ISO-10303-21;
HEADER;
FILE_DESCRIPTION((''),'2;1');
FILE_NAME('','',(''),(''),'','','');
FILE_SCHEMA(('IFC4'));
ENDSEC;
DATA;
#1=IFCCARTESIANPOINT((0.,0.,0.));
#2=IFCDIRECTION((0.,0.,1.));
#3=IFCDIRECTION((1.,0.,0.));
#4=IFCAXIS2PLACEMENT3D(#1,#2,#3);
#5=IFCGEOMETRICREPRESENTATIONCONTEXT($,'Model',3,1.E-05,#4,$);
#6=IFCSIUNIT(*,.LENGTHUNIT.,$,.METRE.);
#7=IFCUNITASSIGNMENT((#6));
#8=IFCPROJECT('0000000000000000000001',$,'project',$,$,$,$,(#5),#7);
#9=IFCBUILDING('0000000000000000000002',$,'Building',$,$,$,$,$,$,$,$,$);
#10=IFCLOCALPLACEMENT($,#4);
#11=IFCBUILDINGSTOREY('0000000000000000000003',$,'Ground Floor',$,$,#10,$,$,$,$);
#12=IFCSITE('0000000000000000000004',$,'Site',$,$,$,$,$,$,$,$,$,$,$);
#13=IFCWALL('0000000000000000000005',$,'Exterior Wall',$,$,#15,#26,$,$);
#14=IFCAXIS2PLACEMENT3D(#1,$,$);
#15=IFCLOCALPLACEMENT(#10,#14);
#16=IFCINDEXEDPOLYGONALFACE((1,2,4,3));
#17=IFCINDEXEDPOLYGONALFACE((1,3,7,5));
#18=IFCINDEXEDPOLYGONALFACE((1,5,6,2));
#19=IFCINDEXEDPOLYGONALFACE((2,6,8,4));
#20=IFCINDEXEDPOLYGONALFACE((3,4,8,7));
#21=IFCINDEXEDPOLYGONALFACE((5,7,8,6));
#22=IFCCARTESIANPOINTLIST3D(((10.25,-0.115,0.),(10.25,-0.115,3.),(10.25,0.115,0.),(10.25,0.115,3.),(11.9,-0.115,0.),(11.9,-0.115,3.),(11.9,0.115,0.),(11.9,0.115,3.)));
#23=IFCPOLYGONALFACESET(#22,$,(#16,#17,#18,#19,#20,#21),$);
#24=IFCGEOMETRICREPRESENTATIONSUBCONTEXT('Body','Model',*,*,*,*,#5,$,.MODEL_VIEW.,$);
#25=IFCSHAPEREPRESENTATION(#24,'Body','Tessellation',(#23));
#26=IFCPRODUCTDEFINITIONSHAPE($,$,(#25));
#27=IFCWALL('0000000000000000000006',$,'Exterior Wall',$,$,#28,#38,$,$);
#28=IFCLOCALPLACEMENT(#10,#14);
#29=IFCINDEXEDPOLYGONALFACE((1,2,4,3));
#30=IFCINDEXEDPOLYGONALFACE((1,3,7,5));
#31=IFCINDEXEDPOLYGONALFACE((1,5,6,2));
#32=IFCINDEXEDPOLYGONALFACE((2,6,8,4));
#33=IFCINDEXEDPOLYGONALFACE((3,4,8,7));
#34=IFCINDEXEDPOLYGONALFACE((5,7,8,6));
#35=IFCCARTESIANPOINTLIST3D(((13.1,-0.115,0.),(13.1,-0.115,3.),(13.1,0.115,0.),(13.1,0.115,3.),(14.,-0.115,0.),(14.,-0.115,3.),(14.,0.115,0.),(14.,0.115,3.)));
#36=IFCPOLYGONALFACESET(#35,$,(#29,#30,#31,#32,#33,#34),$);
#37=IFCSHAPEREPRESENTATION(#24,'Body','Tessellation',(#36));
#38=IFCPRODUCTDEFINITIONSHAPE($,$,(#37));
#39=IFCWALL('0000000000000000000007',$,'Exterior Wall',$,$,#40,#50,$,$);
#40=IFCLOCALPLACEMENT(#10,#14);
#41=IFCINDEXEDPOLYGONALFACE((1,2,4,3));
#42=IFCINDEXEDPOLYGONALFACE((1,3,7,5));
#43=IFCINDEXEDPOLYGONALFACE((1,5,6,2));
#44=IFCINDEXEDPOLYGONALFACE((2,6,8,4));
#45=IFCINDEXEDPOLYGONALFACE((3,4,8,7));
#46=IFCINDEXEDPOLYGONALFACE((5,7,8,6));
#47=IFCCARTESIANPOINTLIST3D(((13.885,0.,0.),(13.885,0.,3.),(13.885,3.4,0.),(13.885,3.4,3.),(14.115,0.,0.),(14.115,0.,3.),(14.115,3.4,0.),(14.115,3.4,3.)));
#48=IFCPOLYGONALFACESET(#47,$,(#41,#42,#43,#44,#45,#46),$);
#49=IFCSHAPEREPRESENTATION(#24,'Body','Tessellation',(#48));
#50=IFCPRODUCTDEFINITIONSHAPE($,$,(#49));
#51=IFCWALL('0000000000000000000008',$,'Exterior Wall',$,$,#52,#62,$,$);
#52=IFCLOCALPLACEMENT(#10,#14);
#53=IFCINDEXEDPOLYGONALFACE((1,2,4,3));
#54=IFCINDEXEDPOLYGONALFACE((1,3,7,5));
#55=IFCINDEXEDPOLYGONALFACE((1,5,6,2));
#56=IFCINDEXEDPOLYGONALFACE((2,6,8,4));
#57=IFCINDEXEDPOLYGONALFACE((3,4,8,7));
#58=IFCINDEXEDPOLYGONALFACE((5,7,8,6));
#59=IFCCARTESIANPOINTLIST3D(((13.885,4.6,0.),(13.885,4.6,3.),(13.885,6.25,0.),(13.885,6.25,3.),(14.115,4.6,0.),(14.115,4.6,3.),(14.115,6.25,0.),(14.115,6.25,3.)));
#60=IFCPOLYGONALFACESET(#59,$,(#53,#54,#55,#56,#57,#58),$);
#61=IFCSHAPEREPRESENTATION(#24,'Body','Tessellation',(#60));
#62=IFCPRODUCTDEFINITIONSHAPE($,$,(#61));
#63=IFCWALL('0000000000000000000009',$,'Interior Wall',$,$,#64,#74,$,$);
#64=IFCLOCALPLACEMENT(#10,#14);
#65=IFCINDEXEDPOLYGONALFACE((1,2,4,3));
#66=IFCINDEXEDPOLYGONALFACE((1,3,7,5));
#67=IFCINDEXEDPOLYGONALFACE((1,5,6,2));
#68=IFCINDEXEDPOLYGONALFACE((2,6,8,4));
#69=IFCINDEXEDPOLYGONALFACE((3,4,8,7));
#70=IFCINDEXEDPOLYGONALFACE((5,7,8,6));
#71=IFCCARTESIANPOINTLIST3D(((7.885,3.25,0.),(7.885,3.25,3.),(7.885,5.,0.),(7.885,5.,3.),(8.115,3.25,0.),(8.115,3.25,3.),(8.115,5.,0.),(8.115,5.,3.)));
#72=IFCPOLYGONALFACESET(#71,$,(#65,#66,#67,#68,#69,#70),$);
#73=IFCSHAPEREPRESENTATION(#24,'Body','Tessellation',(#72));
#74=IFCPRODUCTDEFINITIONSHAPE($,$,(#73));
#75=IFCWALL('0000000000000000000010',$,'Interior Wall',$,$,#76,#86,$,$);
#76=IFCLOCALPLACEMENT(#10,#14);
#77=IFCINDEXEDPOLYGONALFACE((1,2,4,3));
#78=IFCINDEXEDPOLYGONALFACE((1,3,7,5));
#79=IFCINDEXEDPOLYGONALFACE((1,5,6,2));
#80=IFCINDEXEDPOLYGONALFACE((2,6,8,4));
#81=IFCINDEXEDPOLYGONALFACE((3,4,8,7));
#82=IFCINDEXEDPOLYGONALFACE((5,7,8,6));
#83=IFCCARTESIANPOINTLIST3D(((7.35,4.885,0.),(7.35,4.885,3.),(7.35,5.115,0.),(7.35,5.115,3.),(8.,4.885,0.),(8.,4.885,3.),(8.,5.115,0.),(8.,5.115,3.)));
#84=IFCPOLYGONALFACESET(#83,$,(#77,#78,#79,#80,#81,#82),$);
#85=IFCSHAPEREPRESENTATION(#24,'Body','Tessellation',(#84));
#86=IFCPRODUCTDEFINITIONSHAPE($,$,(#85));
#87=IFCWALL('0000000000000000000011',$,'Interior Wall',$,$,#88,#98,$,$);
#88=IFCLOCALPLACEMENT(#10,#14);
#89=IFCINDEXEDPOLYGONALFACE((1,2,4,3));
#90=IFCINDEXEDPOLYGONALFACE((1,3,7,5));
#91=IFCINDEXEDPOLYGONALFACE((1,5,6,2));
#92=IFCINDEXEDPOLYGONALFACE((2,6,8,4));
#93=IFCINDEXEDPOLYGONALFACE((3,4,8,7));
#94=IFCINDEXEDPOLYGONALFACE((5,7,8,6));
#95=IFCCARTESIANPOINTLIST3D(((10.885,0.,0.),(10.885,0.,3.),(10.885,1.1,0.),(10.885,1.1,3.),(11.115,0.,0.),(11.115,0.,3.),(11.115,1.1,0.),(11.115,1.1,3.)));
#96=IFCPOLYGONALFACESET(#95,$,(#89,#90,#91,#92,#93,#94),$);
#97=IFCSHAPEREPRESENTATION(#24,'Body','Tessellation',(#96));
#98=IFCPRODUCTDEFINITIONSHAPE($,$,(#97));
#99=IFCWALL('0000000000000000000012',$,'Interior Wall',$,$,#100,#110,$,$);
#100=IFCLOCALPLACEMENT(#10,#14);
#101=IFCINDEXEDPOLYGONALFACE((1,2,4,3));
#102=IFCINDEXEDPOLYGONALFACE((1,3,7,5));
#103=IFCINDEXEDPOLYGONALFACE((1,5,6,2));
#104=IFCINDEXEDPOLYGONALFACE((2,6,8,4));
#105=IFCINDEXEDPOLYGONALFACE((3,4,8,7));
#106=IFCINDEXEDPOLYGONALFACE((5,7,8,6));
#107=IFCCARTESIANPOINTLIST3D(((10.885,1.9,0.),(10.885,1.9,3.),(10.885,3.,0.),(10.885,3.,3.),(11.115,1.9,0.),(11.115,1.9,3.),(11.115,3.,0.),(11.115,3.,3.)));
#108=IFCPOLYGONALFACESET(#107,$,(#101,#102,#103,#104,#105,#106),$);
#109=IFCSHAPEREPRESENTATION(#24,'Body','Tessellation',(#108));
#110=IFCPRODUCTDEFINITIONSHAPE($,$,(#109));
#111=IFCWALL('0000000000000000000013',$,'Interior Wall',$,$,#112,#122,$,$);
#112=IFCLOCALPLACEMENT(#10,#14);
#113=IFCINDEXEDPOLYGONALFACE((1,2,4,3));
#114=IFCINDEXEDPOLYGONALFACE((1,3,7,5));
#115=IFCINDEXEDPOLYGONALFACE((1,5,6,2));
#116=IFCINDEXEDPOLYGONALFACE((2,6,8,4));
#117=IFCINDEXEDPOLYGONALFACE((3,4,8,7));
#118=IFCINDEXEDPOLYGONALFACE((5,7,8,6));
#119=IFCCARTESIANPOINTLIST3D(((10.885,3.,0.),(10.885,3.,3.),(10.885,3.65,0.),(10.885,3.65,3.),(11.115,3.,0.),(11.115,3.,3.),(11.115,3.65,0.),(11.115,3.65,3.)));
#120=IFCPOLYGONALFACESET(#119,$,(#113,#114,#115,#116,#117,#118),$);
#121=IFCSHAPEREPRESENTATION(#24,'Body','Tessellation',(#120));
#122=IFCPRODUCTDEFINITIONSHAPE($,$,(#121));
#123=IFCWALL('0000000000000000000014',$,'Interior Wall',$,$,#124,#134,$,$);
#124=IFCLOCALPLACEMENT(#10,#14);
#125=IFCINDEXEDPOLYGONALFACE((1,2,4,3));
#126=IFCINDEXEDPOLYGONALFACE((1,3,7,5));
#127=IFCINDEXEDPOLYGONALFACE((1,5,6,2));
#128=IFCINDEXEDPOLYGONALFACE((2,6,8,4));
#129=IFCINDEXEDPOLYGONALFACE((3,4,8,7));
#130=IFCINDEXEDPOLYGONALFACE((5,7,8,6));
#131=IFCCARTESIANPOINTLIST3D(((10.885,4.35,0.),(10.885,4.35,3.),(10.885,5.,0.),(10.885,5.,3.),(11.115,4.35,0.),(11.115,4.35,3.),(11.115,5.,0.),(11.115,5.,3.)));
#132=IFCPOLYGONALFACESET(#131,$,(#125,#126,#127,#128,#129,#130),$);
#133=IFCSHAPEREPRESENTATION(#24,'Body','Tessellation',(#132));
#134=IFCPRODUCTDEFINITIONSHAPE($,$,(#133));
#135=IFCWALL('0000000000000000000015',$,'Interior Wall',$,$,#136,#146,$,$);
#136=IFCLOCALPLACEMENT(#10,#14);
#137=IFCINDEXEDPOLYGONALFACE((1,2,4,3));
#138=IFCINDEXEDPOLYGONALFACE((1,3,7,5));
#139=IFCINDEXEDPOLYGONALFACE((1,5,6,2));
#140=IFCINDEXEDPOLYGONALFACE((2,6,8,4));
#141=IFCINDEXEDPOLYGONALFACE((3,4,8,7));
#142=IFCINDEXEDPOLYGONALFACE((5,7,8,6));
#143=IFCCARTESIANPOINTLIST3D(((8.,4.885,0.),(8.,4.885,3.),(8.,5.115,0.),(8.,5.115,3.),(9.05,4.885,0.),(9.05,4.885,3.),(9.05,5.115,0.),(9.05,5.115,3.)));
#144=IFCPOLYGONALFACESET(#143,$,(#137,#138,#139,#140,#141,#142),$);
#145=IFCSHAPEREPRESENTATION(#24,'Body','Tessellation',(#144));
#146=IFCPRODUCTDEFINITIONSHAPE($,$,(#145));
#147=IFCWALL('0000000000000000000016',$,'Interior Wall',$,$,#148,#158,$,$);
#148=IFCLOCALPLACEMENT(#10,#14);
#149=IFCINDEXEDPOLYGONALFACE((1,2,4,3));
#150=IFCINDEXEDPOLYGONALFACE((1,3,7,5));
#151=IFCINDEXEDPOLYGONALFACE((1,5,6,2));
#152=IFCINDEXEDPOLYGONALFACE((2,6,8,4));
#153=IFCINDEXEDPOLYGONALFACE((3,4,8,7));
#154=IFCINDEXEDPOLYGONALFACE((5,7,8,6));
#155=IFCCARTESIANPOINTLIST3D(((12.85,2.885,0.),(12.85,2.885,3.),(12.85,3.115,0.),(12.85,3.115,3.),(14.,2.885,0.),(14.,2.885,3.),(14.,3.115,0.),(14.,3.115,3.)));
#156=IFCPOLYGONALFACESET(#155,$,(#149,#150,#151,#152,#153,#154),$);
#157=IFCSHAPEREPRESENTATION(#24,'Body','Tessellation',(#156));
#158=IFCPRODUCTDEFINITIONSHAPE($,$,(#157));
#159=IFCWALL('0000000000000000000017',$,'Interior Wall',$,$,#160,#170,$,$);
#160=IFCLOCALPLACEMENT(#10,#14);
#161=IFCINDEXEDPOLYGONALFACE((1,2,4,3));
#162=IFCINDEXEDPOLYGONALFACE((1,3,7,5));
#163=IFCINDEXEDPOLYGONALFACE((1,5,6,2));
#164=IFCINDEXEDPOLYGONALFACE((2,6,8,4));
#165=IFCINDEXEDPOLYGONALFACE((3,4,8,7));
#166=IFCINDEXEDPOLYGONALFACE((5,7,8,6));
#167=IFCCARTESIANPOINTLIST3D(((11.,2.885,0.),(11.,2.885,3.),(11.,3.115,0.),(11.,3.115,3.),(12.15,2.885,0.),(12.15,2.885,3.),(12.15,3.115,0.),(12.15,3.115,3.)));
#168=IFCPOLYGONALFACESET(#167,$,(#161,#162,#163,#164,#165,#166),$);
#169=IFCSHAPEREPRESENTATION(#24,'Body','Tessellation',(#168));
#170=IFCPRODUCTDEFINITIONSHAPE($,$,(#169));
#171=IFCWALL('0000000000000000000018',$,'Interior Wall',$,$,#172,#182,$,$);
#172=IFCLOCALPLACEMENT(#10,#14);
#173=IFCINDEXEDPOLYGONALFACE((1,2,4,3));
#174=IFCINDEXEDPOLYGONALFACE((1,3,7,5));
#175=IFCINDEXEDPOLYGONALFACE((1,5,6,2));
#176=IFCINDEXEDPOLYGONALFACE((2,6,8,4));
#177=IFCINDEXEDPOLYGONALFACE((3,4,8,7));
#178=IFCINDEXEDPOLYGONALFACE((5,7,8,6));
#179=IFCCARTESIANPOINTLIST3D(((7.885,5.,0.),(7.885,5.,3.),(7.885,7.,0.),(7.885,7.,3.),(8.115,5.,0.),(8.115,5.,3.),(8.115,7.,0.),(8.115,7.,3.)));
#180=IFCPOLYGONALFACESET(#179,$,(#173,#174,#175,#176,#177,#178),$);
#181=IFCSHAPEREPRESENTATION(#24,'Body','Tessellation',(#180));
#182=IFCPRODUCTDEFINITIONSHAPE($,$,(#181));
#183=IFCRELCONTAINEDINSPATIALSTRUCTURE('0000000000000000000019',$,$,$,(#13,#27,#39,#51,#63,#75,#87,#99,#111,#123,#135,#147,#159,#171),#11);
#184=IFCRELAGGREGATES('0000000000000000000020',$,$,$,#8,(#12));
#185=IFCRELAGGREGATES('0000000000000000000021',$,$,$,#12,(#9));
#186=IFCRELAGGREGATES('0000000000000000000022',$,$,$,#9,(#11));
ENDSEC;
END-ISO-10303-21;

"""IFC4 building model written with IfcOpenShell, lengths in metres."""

from ifc_helpers import new_model, si_unit, frame, origin_with_axes, place, context, subcontext, project, spatial, indexed_curve, outline, extrude, element, save


model = new_model("IFC4")

# Units and contexts
model_context = context("Model", 3, precision=1e-05, world=origin_with_axes())
body_context = subcontext(model_context, "Body", "Model", "MODEL_VIEW")
ifc_project = project(units=[si_unit("LENGTHUNIT", "METRE")], contexts=[model_context])

# Site, building, storey
site = spatial("IfcSite", under=ifc_project, Name="Site")
building = spatial("IfcBuilding", under=site, Name="Building")
storey_placement = place(None, origin_with_axes())
storey = spatial("IfcBuildingStorey", under=building, at=storey_placement, Name="Ground Floor")

# Walls
wall_1_placement = place(storey_placement, frame((10.25, 0.0, 0.0), z_axis=(0.0, 0.0, 1.0), x_axis=(1.0, 0.0, 0.0)))
element("IfcWall", 1, at=wall_1_placement, inside=storey, Name="Exterior Wall", context=body_context, shape_type="SweptSolid", body=[
    extrude(outline(indexed_curve([(0.0, 0.0), (0.0, 0.23), (1.65, 0.23), (1.65, 0.0), (0.0, 0.0)], self_intersect=False)), frame((0.0, -0.115, 0.0), z_axis=(0.0, 0.0, 1.0), x_axis=(1.0, 0.0, 0.0)), (0.0, 0.0, 1.0), 3.0),
])
wall_2_placement = place(storey_placement, frame((13.1, 0.0, 0.0), z_axis=(0.0, 0.0, 1.0), x_axis=(1.0, 0.0, 0.0)))
element("IfcWall", 2, at=wall_2_placement, inside=storey, Name="Exterior Wall", context=body_context, shape_type="SweptSolid", body=[
    extrude(outline(indexed_curve([(0.0, 0.0), (0.0, 0.23), (0.9, 0.23), (0.9, 0.0), (0.0, 0.0)], self_intersect=False)), frame((0.0, -0.115, 0.0), z_axis=(0.0, 0.0, 1.0), x_axis=(1.0, 0.0, 0.0)), (0.0, 0.0, 1.0), 3.0),
])
wall_3_placement = place(storey_placement, frame((14.0, 0.0, 0.0), z_axis=(0.0, 0.0, 1.0), x_axis=(0.0, 1.0, 0.0)))
element("IfcWall", 3, at=wall_3_placement, inside=storey, Name="Exterior Wall", context=body_context, shape_type="SweptSolid", body=[
    extrude(outline(indexed_curve([(0.0, 0.0), (0.0, 0.23), (3.4, 0.23), (3.4, 0.0), (0.0, 0.0)], self_intersect=False)), frame((0.0, -0.115, 0.0), z_axis=(0.0, 0.0, 1.0), x_axis=(1.0, 0.0, 0.0)), (0.0, 0.0, 1.0), 3.0),
])
wall_4_placement = place(storey_placement, frame((14.0, 4.6, 0.0), z_axis=(0.0, 0.0, 1.0), x_axis=(0.0, 1.0, 0.0)))
element("IfcWall", 4, at=wall_4_placement, inside=storey, Name="Exterior Wall", context=body_context, shape_type="SweptSolid", body=[
    extrude(outline(indexed_curve([(0.0, 0.0), (0.0, 0.23), (1.65, 0.23), (1.65, 0.0), (0.0, 0.0)], self_intersect=False)), frame((0.0, -0.115, 0.0), z_axis=(0.0, 0.0, 1.0), x_axis=(1.0, 0.0, 0.0)), (0.0, 0.0, 1.0), 3.0),
])
wall_5_placement = place(storey_placement, frame((8.0, 3.25, 0.0), z_axis=(0.0, 0.0, 1.0), x_axis=(0.0, 1.0, 0.0)))
element("IfcWall", 5, at=wall_5_placement, inside=storey, Name="Interior Wall", context=body_context, shape_type="SweptSolid", body=[
    extrude(outline(indexed_curve([(0.0, 0.0), (0.0, 0.23), (1.75, 0.23), (1.75, 0.0), (0.0, 0.0)], self_intersect=False)), frame((0.0, -0.115, 0.0), z_axis=(0.0, 0.0, 1.0), x_axis=(1.0, 0.0, 0.0)), (0.0, 0.0, 1.0), 3.0),
])
wall_6_placement = place(storey_placement, frame((8.0, 5.0, 0.0), z_axis=(0.0, 0.0, 1.0), x_axis=(-1.0, 0.0, 0.0)))
element("IfcWall", 6, at=wall_6_placement, inside=storey, Name="Interior Wall", context=body_context, shape_type="SweptSolid", body=[
    extrude(outline(indexed_curve([(0.0, 0.0), (0.0, 0.23), (0.65, 0.23), (0.65, 0.0), (0.0, 0.0)], self_intersect=False)), frame((0.0, -0.115, 0.0), z_axis=(0.0, 0.0, 1.0), x_axis=(1.0, 0.0, 0.0)), (0.0, 0.0, 1.0), 3.0),
])
for number, where, z_axis, x_axis, name in (
    (7, (11.0, 0.0, 0.0), (0.0, 0.0, 1.0), (0.0, 1.0, 0.0), "Interior Wall"),
    (8, (11.0, 1.9, 0.0), (0.0, 0.0, 1.0), (0.0, 1.0, 0.0), "Interior Wall"),
):
    element("IfcWall", number, at=place(storey_placement, frame(where, z_axis=z_axis, x_axis=x_axis)), inside=storey, Name=name, context=body_context, shape_type="SweptSolid", body=[
        extrude(outline(indexed_curve([(0.0, 0.0), (0.0, 0.23), (1.1, 0.23), (1.1, 0.0), (0.0, 0.0)], self_intersect=False)), frame((0.0, -0.115, 0.0), z_axis=(0.0, 0.0, 1.0), x_axis=(1.0, 0.0, 0.0)), (0.0, 0.0, 1.0), 3.0),
    ])
wall_7_placement = place(storey_placement, frame((11.0, 3.0, 0.0), z_axis=(0.0, 0.0, 1.0), x_axis=(0.0, 1.0, 0.0)))
element("IfcWall", 9, at=wall_7_placement, inside=storey, Name="Interior Wall", context=body_context, shape_type="SweptSolid", body=[
    extrude(outline(indexed_curve([(0.0, 0.0), (0.0, 0.23), (0.65, 0.23), (0.65, 0.0), (0.0, 0.0)], self_intersect=False)), frame((0.0, -0.115, 0.0), z_axis=(0.0, 0.0, 1.0), x_axis=(1.0, 0.0, 0.0)), (0.0, 0.0, 1.0), 3.0),
])
wall_8_placement = place(storey_placement, frame((11.0, 4.35, 0.0), z_axis=(0.0, 0.0, 1.0), x_axis=(0.0, 1.0, 0.0)))
element("IfcWall", 10, at=wall_8_placement, inside=storey, Name="Interior Wall", context=body_context, shape_type="SweptSolid", body=[
    extrude(outline(indexed_curve([(0.0, 0.0), (0.0, 0.23), (0.65, 0.23), (0.65, 0.0), (0.0, 0.0)], self_intersect=False)), frame((0.0, -0.115, 0.0), z_axis=(0.0, 0.0, 1.0), x_axis=(1.0, 0.0, 0.0)), (0.0, 0.0, 1.0), 3.0),
])
wall_9_placement = place(storey_placement, frame((9.05, 5.0, 0.0), z_axis=(0.0, 0.0, 1.0), x_axis=(-1.0, 0.0, 0.0)))
element("IfcWall", 11, at=wall_9_placement, inside=storey, Name="Interior Wall", context=body_context, shape_type="SweptSolid", body=[
    extrude(outline(indexed_curve([(0.0, 0.0), (0.0, 0.23), (1.05, 0.23), (1.05, 0.0), (0.0, 0.0)], self_intersect=False)), frame((0.0, -0.115, 0.0), z_axis=(0.0, 0.0, 1.0), x_axis=(1.0, 0.0, 0.0)), (0.0, 0.0, 1.0), 3.0),
])
for number, where, z_axis, x_axis, name in (
    (12, (14.0, 3.0, 0.0), (0.0, 0.0, 1.0), (-1.0, 0.0, 0.0), "Interior Wall"),
    (13, (12.15, 3.0, 0.0), (0.0, 0.0, 1.0), (-1.0, 0.0, 0.0), "Interior Wall"),
):
    element("IfcWall", number, at=place(storey_placement, frame(where, z_axis=z_axis, x_axis=x_axis)), inside=storey, Name=name, context=body_context, shape_type="SweptSolid", body=[
        extrude(outline(indexed_curve([(0.0, 0.0), (0.0, 0.23), (1.15, 0.23), (1.15, 0.0), (0.0, 0.0)], self_intersect=False)), frame((0.0, -0.115, 0.0), z_axis=(0.0, 0.0, 1.0), x_axis=(1.0, 0.0, 0.0)), (0.0, 0.0, 1.0), 3.0),
    ])
wall_10_placement = place(storey_placement, frame((8.0, 5.0, 0.0), z_axis=(0.0, 0.0, 1.0), x_axis=(0.0, 1.0, 0.0)))
element("IfcWall", 14, at=wall_10_placement, inside=storey, Name="Interior Wall", context=body_context, shape_type="SweptSolid", body=[
    extrude(outline(indexed_curve([(0.0, 0.0), (0.0, 0.23), (2.0, 0.23), (2.0, 0.0), (0.0, 0.0)], self_intersect=False)), frame((0.0, -0.115, 0.0), z_axis=(0.0, 0.0, 1.0), x_axis=(1.0, 0.0, 0.0)), (0.0, 0.0, 1.0), 3.0),
])

save(model, "model.ifc")
